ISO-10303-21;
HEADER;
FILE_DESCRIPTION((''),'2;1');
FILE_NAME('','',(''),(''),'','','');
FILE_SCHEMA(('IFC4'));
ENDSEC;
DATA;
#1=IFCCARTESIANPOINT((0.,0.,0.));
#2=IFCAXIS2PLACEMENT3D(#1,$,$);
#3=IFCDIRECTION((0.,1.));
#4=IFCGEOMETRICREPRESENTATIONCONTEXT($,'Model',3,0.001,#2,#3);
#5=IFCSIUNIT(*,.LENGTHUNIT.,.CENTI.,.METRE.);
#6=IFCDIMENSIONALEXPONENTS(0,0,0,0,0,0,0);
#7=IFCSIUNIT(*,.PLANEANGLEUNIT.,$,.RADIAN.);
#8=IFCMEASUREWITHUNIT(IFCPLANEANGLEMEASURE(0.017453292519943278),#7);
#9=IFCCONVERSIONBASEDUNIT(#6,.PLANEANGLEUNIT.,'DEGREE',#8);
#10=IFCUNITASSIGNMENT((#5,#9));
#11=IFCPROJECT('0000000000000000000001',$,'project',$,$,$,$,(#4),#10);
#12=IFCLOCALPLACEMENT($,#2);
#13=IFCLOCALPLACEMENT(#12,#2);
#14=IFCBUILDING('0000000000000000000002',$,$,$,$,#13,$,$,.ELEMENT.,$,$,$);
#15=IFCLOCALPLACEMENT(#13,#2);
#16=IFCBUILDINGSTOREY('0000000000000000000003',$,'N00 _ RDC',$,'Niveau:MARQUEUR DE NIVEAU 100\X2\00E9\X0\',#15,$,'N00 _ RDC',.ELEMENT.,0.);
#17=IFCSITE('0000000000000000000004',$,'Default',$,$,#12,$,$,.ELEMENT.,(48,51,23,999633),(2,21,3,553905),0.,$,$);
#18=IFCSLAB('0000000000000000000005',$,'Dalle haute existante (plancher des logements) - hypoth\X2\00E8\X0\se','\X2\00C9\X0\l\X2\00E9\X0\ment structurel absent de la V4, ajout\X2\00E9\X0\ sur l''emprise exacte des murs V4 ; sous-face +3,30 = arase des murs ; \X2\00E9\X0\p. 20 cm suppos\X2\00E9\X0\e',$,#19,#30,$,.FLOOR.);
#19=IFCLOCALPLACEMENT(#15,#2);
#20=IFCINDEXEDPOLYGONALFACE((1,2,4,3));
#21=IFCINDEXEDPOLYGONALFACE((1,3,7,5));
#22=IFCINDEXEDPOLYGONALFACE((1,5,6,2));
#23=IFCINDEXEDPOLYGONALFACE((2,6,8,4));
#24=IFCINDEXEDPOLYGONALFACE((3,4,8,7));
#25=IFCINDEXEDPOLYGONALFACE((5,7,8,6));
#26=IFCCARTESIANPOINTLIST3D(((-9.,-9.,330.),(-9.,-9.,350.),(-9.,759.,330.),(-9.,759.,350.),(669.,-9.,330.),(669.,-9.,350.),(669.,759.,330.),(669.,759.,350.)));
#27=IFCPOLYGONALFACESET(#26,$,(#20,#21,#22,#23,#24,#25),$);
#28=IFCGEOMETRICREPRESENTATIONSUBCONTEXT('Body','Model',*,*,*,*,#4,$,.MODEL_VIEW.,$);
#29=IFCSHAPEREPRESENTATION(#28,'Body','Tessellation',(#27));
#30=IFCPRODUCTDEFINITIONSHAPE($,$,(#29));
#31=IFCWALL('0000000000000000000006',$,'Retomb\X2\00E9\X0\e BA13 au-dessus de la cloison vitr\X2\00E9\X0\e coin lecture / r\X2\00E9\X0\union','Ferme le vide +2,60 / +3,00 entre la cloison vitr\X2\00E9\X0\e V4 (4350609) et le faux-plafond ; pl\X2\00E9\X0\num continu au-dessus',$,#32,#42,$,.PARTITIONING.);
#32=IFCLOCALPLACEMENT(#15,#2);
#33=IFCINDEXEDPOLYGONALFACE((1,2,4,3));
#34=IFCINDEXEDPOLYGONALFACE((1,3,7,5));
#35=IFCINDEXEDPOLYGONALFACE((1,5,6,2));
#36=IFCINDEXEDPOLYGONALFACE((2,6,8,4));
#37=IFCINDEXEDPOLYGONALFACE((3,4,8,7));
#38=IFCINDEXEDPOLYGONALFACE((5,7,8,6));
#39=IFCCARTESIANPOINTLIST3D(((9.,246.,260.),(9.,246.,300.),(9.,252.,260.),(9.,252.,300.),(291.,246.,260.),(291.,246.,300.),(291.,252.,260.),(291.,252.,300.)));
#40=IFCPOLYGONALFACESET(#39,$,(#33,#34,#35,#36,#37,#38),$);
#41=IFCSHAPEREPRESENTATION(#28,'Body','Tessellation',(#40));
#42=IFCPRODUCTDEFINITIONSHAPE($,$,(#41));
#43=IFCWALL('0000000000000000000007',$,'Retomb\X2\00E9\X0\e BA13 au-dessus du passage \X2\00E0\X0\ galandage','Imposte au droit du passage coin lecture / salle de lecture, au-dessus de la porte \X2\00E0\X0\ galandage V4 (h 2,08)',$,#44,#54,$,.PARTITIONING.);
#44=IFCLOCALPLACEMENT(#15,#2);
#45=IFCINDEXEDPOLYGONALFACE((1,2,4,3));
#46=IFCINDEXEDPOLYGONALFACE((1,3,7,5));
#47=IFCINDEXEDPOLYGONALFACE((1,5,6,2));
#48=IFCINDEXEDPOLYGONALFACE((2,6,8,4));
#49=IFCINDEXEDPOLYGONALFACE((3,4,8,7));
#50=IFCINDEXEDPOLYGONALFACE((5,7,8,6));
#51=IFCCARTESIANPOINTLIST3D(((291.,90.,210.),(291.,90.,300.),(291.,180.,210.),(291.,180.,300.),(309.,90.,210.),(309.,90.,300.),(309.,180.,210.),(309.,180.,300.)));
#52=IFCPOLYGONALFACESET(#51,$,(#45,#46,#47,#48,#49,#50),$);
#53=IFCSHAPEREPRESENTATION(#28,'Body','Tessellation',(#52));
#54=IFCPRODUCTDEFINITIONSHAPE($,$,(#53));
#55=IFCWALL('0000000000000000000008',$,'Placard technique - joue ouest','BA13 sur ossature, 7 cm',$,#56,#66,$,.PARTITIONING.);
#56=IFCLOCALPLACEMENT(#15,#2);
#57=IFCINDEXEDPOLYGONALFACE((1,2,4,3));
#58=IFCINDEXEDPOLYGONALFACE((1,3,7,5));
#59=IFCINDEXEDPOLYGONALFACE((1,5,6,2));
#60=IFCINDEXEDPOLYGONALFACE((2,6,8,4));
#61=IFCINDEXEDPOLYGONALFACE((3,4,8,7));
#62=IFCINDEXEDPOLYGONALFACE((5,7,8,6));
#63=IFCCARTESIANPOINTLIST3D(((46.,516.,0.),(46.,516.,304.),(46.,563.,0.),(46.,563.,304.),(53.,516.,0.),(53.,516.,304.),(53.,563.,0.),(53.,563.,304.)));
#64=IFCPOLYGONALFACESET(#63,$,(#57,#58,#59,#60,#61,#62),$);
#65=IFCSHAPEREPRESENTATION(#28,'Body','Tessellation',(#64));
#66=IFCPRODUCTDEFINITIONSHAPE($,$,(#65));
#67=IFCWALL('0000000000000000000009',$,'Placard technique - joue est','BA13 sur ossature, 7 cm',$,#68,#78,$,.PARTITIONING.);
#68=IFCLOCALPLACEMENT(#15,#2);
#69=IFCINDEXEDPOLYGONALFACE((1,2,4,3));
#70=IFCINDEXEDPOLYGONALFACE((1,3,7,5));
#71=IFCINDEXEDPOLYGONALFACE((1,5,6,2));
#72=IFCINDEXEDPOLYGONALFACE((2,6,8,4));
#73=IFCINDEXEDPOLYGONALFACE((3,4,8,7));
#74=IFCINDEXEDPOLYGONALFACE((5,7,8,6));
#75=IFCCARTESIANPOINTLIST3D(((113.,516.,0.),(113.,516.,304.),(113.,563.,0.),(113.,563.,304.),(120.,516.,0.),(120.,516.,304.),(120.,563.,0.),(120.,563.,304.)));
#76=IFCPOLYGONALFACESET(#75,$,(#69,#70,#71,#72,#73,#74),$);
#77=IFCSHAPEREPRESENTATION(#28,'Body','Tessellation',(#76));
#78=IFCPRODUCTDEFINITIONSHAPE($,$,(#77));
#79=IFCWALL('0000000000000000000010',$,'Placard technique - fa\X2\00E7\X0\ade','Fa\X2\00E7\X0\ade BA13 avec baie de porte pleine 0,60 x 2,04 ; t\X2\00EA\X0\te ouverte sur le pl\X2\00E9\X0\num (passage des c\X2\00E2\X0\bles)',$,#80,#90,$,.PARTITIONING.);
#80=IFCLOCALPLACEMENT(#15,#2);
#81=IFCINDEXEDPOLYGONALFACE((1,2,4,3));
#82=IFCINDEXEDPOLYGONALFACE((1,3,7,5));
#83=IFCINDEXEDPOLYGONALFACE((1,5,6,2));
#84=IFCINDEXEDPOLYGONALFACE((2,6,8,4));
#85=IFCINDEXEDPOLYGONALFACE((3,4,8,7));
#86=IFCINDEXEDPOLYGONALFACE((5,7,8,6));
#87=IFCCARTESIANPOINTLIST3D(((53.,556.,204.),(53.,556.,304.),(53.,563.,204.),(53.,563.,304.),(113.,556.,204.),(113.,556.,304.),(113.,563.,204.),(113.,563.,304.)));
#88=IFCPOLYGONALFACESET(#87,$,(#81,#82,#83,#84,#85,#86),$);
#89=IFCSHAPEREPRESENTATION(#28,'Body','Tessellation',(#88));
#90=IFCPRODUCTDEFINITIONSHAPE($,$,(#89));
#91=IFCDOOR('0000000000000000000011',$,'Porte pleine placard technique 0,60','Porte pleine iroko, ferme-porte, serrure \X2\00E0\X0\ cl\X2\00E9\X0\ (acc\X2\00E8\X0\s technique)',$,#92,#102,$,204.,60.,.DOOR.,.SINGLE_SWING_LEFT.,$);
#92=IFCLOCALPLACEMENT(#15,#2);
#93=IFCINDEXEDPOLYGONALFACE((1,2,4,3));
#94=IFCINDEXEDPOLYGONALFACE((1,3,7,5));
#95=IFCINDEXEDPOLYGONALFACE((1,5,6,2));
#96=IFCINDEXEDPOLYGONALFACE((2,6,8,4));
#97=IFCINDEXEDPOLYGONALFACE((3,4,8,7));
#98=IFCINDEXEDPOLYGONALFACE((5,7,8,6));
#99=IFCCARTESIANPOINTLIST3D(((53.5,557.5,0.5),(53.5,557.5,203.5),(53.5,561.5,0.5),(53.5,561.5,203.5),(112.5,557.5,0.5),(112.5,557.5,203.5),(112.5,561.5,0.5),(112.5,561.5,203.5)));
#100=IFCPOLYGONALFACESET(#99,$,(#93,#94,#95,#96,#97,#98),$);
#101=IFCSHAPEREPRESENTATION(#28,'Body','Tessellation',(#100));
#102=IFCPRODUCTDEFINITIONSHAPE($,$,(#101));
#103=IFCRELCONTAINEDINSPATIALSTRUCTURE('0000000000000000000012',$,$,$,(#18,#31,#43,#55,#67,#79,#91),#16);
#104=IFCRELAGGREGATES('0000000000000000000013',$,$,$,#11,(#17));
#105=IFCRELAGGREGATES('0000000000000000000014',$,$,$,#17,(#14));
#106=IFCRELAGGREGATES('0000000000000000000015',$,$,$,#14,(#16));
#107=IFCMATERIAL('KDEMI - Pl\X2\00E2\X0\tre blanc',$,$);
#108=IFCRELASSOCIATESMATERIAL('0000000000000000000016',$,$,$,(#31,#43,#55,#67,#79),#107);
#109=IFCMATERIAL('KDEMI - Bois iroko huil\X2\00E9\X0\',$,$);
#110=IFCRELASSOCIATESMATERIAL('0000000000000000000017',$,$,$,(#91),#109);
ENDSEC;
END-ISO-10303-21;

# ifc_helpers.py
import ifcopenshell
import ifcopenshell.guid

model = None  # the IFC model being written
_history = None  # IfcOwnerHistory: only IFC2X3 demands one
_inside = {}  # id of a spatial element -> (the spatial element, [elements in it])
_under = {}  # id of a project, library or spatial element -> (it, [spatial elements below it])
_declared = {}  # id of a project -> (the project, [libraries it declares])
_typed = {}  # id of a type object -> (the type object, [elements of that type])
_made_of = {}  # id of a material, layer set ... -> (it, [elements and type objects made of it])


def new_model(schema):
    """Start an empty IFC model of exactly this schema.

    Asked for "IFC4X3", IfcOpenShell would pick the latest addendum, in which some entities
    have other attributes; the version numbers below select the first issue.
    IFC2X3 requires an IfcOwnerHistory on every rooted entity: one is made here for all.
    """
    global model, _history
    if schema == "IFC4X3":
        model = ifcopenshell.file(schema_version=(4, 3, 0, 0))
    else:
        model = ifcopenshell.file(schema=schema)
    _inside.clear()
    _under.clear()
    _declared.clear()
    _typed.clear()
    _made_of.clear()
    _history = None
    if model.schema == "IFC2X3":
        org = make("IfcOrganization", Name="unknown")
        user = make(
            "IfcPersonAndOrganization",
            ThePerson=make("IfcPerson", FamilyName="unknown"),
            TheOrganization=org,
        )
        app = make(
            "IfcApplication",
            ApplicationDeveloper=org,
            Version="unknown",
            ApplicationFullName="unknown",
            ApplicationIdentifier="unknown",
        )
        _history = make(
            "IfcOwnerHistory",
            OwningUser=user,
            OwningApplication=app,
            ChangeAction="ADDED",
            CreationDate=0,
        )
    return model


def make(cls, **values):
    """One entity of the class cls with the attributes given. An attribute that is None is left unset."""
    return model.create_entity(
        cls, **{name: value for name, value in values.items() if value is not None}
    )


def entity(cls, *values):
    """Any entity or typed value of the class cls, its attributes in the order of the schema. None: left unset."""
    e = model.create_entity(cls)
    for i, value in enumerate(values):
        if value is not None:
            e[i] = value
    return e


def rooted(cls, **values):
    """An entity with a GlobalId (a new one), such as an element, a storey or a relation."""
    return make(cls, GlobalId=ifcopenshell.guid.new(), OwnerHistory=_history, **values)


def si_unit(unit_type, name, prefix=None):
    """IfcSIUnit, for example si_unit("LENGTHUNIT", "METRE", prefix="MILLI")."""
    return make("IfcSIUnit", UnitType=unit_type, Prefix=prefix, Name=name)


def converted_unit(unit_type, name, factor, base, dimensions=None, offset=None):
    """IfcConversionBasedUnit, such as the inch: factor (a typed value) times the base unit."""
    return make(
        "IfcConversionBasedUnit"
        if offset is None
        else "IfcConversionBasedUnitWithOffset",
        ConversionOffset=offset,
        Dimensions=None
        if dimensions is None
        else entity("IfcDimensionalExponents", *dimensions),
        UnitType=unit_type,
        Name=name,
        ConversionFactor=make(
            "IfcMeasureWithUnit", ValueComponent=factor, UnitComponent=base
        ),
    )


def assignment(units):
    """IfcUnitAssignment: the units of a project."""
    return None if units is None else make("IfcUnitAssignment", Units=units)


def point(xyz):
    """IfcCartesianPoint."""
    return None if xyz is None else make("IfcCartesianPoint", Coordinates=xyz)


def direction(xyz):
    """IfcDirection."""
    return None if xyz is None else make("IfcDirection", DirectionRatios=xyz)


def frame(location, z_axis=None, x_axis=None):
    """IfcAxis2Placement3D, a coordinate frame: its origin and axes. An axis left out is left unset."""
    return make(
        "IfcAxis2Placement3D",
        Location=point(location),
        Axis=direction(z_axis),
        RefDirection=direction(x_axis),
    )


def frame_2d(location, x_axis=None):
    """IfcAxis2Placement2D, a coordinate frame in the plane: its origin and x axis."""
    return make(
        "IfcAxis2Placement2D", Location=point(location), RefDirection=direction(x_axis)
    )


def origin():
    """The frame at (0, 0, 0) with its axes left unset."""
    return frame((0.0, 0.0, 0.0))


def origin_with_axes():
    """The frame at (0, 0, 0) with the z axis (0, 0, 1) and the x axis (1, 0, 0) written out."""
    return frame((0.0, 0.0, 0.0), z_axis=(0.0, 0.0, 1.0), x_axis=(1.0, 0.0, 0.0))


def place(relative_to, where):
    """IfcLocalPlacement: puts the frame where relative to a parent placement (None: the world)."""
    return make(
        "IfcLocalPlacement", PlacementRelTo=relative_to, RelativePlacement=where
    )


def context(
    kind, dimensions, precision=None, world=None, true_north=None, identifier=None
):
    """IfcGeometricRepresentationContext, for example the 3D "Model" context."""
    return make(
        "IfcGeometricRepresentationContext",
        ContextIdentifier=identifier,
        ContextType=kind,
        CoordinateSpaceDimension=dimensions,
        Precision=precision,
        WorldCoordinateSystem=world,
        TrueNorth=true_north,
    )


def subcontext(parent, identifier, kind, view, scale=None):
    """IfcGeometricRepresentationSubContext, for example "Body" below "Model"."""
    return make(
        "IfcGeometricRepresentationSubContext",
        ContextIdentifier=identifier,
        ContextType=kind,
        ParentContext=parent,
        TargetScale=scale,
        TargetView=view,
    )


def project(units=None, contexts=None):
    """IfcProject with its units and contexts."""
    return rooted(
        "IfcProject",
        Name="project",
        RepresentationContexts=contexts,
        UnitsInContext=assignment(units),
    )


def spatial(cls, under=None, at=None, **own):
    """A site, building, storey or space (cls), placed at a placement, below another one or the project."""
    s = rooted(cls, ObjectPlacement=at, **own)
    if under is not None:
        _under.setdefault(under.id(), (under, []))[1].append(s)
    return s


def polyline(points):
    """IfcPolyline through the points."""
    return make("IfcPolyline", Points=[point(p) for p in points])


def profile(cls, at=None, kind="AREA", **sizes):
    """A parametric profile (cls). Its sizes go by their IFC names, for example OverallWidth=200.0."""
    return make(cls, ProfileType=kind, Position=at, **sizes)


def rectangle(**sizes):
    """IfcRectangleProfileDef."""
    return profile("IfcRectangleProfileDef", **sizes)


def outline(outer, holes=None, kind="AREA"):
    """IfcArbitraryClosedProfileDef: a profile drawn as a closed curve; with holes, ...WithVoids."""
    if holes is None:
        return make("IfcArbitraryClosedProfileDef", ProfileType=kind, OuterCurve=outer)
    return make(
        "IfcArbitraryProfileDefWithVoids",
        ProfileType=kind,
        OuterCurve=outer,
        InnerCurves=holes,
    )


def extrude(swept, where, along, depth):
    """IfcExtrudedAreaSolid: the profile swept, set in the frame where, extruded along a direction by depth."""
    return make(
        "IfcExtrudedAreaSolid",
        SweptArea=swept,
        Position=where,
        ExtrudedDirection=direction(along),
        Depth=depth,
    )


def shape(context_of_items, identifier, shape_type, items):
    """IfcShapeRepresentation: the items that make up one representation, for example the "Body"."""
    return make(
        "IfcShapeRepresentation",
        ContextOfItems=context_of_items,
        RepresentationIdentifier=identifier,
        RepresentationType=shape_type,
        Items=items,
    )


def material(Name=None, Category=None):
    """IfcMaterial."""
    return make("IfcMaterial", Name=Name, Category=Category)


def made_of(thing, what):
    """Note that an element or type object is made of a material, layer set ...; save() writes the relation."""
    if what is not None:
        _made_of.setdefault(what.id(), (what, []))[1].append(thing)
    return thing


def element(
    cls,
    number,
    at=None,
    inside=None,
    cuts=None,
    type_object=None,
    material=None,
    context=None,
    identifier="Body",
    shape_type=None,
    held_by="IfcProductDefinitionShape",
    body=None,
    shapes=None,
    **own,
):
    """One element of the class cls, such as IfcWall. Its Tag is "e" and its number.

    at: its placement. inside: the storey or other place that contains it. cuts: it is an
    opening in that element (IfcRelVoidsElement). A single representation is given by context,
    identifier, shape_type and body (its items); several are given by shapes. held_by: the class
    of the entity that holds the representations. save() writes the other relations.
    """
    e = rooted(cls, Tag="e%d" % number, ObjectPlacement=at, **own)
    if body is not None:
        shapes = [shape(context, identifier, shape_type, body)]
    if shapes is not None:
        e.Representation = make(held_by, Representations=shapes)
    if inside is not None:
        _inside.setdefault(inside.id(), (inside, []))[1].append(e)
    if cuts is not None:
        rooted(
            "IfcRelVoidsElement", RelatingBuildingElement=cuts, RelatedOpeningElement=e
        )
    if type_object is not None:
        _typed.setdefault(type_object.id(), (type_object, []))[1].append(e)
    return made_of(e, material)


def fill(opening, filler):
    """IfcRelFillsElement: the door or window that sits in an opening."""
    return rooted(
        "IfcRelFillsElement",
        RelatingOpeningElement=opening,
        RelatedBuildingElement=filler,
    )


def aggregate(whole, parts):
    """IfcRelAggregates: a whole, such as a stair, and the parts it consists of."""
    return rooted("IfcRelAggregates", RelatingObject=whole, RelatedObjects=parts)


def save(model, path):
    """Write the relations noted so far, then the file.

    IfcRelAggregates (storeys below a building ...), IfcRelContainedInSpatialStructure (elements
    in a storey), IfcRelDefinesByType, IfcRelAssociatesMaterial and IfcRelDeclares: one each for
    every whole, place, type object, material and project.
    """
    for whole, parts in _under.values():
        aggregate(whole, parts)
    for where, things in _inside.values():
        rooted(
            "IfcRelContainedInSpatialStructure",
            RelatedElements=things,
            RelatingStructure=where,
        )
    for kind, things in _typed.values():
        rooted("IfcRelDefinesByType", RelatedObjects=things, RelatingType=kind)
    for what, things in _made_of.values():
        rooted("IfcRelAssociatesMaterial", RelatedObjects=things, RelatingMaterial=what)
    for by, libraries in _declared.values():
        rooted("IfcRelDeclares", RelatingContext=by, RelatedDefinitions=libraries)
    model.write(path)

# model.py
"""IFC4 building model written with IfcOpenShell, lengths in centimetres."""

from ifc_helpers import new_model, entity, si_unit, converted_unit, direction, frame, frame_2d, origin, origin_with_axes, place, context, subcontext, project, spatial, polyline, rectangle, outline, extrude, material, element, fill, save


model = new_model("IFC4")

# Units and contexts
model_context = context("Model", 3, precision=0.001, world=origin(), true_north=direction((0.0, 1.0)))
body_context = subcontext(model_context, "Body", "Model", "MODEL_VIEW")
ifc_project = project(units=[si_unit("LENGTHUNIT", "METRE", prefix="CENTI"), converted_unit("PLANEANGLEUNIT", "DEGREE", entity("IfcPlaneAngleMeasure", 0.017453292519943278), si_unit("PLANEANGLEUNIT", "RADIAN"), dimensions=[0, 0, 0, 0, 0, 0, 0])], contexts=[model_context])

# Site, building, storey
site_placement = place(None, origin())
site = spatial("IfcSite", under=ifc_project, at=site_placement, Name="Default", CompositionType="ELEMENT", RefLatitude=(48, 51, 23, 999633), RefLongitude=(2, 21, 3, 553905), RefElevation=0.0)
building_placement = place(site_placement, origin())
building = spatial("IfcBuilding", under=site, at=building_placement, CompositionType="ELEMENT")
storey_placement = place(building_placement, origin())
storey = spatial("IfcBuildingStorey", under=building, at=storey_placement, Name="N00 _ RDC", ObjectType="Niveau:MARQUEUR DE NIVEAU 100é", LongName="N00 _ RDC", CompositionType="ELEMENT", Elevation=0.0)

# Slab
slab_placement = place(storey_placement, origin_with_axes())
element("IfcSlab", 1, at=slab_placement, inside=storey, Name="Dalle haute existante (plancher des logements) - hypothèse", Description="Élément structurel absent de la V4, ajouté sur l'emprise exacte des murs V4 ; sous-face +3,30 = arase des murs ; ép. 20 cm supposée", PredefinedType="FLOOR", context=body_context, shape_type="SweptSolid", body=[
    extrude(outline(polyline([(669.0, -9.0), (-9.0, -9.0), (-9.0, 759.0), (669.0, 759.0), (669.0, -9.0)])), frame((0.0, 0.0, 330.0)), (0.0, 0.0, 1.0), 20.0),
])

# Walls
ifc_material_1 = material(Name="KDEMI - Plâtre blanc")
wall_1_placement = place(storey_placement, origin_with_axes())
element("IfcWall", 2, at=wall_1_placement, inside=storey, material=ifc_material_1, Name="Retombée BA13 au-dessus de la cloison vitrée coin lecture / réunion", Description="Ferme le vide +2,60 / +3,00 entre la cloison vitrée V4 (4350609) et le faux-plafond ; plénum continu au-dessus", PredefinedType="PARTITIONING", context=body_context, shape_type="SweptSolid", body=[
    extrude(rectangle(XDim=282.0, YDim=6.0, at=frame_2d((150.0, 249.0))), frame((0.0, 0.0, 260.0)), (0.0, 0.0, 1.0), 40.0),
])
wall_2_placement = place(storey_placement, origin_with_axes())
element("IfcWall", 3, at=wall_2_placement, inside=storey, material=ifc_material_1, Name="Retombée BA13 au-dessus du passage à galandage", Description="Imposte au droit du passage coin lecture / salle de lecture, au-dessus de la porte à galandage V4 (h 2,08)", PredefinedType="PARTITIONING", context=body_context, shape_type="SweptSolid", body=[
    extrude(rectangle(XDim=18.0, YDim=90.0, at=frame_2d((300.0, 135.0))), frame((0.0, 0.0, 210.0)), (0.0, 0.0, 1.0), 90.0),
])
wall_3_placement = place(storey_placement, origin_with_axes())
element("IfcWall", 4, at=wall_3_placement, inside=storey, material=ifc_material_1, Name="Placard technique - joue ouest", Description="BA13 sur ossature, 7 cm", PredefinedType="PARTITIONING", context=body_context, shape_type="SweptSolid", body=[
    extrude(rectangle(XDim=7.0, YDim=47.0, at=frame_2d((49.5, 539.5))), origin(), (0.0, 0.0, 1.0), 304.0),
])
wall_4_placement = place(storey_placement, origin_with_axes())
element("IfcWall", 5, at=wall_4_placement, inside=storey, material=ifc_material_1, Name="Placard technique - joue est", Description="BA13 sur ossature, 7 cm", PredefinedType="PARTITIONING", context=body_context, shape_type="SweptSolid", body=[
    extrude(rectangle(XDim=7.0, YDim=47.0, at=frame_2d((116.5, 539.5))), origin(), (0.0, 0.0, 1.0), 304.0),
])

# Wall, opening, door
wall_5_placement = place(storey_placement, origin_with_axes())
wall_5 = element("IfcWall", 6, at=wall_5_placement, inside=storey, material=ifc_material_1, Name="Placard technique - façade", Description="Façade BA13 avec baie de porte pleine 0,60 x 2,04 ; tête ouverte sur le plénum (passage des câbles)", PredefinedType="PARTITIONING", context=body_context, shape_type="SweptSolid", body=[
    extrude(rectangle(XDim=60.0, YDim=7.0, at=frame_2d((83.0, 559.5))), origin(), (0.0, 0.0, 1.0), 304.0),
])
opening_placement = place(wall_5_placement, origin_with_axes())
opening = element("IfcOpeningElement", 7, at=opening_placement, cuts=wall_5, PredefinedType="OPENING", context=body_context, shape_type="SweptSolid", body=[
    extrude(rectangle(XDim=60.0, YDim=9.0, at=frame_2d((83.0, 559.5))), origin(), (0.0, 0.0, 1.0), 204.0),
])
ifc_material_2 = material(Name="KDEMI - Bois iroko huilé")
door_placement = place(storey_placement, origin_with_axes())
door = element("IfcDoor", 8, at=door_placement, inside=storey, material=ifc_material_2, Name="Porte pleine placard technique 0,60", Description="Porte pleine iroko, ferme-porte, serrure à clé (accès technique)", OperationType="SINGLE_SWING_LEFT", OverallHeight=204.0, OverallWidth=60.0, PredefinedType="DOOR", context=body_context, shape_type="SweptSolid", body=[
    extrude(rectangle(XDim=59.0, YDim=4.0, at=frame_2d((83.0, 559.5))), frame((0.0, 0.0, 0.5)), (0.0, 0.0, 1.0), 203.0),
])
fill(opening, door)

save(model, "model.ifc")
